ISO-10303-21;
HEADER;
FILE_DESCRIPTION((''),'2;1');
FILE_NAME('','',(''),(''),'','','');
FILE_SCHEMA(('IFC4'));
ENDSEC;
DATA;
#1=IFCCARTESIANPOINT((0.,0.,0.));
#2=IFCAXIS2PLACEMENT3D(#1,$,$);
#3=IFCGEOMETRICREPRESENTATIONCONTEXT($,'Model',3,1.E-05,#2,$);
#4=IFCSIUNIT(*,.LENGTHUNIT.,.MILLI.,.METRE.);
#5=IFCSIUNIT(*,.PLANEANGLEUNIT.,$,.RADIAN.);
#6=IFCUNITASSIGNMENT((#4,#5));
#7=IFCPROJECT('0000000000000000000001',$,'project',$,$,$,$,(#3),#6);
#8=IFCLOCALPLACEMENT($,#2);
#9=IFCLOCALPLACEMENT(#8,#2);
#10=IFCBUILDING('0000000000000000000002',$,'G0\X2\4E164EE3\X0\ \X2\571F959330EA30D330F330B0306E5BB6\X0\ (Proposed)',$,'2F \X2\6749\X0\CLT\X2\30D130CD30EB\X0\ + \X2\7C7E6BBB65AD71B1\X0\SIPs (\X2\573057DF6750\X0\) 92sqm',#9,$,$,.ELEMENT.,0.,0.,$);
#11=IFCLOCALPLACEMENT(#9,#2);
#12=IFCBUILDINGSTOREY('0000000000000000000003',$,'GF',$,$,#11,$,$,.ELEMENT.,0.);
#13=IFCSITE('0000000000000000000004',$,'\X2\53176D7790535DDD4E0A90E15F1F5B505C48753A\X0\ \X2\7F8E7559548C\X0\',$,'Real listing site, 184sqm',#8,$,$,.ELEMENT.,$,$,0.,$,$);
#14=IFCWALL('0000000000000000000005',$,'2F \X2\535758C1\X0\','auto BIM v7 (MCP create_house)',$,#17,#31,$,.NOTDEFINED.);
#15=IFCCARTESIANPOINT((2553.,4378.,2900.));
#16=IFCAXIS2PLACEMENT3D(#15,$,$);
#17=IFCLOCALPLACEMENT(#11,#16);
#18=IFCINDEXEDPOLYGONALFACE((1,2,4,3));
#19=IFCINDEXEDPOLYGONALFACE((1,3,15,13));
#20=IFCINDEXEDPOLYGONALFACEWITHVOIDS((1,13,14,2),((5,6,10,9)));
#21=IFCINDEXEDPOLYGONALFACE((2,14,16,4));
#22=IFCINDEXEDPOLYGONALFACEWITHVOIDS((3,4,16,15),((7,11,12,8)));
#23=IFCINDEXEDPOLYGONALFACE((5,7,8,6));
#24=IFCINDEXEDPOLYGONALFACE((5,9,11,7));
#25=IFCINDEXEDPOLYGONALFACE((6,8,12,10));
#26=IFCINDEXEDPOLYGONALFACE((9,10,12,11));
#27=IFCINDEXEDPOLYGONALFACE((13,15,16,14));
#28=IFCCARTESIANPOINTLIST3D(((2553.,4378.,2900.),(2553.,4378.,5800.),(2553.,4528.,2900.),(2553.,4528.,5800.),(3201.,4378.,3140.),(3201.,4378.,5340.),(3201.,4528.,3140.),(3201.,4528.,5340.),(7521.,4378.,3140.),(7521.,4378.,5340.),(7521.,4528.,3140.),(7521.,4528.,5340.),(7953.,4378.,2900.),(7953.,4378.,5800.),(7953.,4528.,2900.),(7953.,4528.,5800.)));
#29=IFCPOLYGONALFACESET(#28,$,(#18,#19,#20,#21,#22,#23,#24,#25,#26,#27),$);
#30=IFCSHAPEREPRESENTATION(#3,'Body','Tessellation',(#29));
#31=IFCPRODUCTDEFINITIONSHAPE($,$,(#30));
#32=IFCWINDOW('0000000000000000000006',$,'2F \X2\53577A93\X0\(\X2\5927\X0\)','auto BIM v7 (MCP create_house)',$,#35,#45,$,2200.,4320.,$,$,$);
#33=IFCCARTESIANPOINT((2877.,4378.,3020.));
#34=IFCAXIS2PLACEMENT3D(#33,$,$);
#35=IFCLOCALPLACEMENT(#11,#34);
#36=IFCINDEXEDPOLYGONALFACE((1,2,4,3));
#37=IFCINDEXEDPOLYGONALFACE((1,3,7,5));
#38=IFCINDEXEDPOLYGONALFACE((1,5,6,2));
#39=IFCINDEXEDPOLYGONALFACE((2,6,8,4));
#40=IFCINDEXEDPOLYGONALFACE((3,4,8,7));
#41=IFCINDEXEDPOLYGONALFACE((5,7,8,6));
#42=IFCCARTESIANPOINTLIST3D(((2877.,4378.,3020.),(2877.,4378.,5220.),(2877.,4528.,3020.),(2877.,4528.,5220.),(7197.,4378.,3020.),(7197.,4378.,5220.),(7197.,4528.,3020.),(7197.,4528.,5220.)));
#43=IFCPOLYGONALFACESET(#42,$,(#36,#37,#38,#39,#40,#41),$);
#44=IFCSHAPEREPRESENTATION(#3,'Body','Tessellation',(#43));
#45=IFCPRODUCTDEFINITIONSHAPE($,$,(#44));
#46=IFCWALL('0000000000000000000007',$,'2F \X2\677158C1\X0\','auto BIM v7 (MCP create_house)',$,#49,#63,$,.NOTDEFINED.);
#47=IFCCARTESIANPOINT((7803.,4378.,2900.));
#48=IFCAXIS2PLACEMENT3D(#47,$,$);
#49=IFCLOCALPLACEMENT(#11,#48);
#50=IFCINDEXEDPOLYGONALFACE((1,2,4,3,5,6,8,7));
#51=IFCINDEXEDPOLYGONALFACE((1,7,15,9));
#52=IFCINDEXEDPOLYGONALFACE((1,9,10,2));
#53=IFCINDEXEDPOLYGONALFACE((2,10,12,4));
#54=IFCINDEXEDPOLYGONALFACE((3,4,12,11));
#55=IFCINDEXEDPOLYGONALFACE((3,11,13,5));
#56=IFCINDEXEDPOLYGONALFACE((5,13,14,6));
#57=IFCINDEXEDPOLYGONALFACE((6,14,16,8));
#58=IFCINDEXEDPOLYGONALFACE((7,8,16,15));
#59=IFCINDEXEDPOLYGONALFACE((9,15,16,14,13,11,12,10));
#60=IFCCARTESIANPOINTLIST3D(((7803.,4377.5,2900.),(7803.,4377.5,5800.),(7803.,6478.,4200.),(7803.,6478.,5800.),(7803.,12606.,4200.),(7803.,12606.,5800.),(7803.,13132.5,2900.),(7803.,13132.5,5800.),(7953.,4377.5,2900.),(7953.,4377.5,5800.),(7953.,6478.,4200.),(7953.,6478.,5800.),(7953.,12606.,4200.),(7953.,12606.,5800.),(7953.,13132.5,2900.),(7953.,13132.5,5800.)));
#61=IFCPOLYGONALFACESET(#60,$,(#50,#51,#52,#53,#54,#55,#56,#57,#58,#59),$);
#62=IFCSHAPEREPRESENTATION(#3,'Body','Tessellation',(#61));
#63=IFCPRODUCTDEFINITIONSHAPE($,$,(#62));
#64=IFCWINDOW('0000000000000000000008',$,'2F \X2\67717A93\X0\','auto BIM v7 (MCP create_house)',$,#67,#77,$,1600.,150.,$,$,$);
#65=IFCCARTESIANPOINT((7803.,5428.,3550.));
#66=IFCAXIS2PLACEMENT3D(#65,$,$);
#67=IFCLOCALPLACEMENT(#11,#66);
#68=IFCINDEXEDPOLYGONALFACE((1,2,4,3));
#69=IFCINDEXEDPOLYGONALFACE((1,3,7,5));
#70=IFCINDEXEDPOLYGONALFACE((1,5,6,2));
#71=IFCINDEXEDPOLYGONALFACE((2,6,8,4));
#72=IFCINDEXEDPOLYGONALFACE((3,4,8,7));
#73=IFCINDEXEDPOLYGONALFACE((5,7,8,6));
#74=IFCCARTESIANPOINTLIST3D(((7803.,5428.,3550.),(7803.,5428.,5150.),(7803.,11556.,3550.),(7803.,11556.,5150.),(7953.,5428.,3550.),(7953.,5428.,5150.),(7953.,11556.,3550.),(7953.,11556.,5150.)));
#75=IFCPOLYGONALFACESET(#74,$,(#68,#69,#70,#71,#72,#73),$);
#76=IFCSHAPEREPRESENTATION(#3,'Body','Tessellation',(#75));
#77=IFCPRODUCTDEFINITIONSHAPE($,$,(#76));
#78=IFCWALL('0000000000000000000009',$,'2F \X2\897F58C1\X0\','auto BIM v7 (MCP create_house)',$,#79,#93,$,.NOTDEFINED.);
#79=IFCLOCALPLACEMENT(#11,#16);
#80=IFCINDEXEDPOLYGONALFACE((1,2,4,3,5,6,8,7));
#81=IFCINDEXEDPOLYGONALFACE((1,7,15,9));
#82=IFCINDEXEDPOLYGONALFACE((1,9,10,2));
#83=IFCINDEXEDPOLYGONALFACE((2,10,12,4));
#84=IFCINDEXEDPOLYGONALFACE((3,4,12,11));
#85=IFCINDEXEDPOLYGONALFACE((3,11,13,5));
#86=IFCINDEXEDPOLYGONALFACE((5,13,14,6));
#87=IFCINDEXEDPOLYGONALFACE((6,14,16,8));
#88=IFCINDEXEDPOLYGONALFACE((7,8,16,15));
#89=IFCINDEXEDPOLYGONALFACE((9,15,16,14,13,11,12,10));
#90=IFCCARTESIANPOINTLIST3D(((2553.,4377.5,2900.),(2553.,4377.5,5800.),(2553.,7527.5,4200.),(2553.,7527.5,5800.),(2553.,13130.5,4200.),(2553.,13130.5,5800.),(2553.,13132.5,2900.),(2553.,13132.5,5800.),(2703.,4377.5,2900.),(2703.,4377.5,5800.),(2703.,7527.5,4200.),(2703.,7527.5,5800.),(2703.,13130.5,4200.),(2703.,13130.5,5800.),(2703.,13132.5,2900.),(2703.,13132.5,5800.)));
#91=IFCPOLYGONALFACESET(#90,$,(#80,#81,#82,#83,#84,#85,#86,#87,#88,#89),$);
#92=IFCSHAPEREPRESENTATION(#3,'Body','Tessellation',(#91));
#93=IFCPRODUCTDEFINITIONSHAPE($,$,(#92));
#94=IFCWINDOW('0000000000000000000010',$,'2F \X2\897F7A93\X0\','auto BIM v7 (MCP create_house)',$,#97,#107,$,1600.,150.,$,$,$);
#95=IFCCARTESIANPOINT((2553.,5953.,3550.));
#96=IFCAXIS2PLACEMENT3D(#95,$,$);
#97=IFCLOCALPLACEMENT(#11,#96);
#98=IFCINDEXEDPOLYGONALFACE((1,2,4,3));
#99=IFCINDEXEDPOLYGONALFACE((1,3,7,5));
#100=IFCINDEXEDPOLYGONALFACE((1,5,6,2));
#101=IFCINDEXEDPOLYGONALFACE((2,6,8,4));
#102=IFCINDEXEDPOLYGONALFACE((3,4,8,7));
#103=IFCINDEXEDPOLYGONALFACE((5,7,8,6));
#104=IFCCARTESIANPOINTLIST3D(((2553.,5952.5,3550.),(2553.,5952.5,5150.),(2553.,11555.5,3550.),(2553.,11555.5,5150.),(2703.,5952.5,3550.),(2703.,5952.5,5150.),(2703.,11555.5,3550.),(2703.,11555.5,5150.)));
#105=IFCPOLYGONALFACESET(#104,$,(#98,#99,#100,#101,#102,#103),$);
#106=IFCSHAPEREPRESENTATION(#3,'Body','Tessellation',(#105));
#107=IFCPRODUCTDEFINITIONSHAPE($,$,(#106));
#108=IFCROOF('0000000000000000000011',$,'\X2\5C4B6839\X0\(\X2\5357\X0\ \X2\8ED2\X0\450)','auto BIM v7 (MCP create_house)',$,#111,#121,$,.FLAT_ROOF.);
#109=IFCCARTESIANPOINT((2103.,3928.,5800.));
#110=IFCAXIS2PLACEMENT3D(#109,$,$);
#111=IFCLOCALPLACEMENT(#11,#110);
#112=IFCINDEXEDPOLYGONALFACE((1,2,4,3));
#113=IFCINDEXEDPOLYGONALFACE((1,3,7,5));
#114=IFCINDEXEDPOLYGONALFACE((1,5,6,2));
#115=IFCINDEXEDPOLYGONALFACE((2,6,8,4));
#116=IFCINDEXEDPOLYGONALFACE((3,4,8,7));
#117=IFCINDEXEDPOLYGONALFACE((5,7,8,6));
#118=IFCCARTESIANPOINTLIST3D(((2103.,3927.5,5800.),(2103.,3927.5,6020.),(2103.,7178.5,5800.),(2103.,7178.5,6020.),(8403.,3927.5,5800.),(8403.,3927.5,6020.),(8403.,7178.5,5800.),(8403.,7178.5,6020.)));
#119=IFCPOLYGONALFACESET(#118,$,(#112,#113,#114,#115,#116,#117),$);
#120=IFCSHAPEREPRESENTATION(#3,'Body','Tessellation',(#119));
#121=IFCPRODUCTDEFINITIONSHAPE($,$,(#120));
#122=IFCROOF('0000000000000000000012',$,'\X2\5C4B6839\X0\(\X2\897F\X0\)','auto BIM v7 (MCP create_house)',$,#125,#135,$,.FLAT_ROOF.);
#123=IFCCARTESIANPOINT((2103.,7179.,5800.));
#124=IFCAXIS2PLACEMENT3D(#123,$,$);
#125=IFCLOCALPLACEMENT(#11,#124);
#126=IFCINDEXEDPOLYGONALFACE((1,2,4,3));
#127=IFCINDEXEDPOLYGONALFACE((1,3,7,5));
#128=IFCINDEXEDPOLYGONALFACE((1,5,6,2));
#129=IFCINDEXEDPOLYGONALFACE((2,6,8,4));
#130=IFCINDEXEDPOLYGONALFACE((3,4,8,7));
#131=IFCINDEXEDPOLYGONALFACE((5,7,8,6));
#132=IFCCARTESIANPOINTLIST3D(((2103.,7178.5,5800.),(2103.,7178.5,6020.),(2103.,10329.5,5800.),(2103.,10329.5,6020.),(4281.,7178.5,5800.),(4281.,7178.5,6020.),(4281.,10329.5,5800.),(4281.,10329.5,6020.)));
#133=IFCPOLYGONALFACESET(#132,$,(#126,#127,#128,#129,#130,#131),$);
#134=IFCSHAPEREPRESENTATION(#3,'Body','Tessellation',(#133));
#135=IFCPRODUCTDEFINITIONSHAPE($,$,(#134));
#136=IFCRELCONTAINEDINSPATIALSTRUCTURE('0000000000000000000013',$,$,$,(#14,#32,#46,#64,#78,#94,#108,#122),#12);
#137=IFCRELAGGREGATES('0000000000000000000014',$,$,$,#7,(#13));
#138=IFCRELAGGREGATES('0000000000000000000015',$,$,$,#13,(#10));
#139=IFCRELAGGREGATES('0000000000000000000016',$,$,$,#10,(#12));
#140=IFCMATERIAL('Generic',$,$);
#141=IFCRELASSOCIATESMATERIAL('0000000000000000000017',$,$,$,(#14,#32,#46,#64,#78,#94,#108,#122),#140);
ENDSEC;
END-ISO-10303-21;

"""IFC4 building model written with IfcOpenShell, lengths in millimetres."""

from ifc_helpers import new_model, si_unit, frame, frame_2d, origin, place, context, project, spatial, rectangle, extrude, material, element, fill, save


model = new_model("IFC4")

# Units and contexts
model_context = context("Model", 3, precision=1e-05, world=origin())
ifc_project = project(units=[si_unit("LENGTHUNIT", "METRE", prefix="MILLI"), si_unit("PLANEANGLEUNIT", "RADIAN")], contexts=[model_context])

# Site, building, storey
site_placement = place(None, origin())
site = spatial("IfcSite", under=ifc_project, at=site_placement, Name="北海道川上郡弟子屈町 美留和", ObjectType="Real listing site, 184sqm", CompositionType="ELEMENT", RefElevation=0.0)
building_placement = place(site_placement, origin())
building = spatial("IfcBuilding", under=site, at=building_placement, Name="G0世代 土間リビングの家 (Proposed)", ObjectType="2F 杉CLTパネル + 籾殻断熱SIPs (地域材) 92sqm", CompositionType="ELEMENT", ElevationOfRefHeight=0.0, ElevationOfTerrain=0.0)
storey_placement = place(building_placement, origin())
storey = spatial("IfcBuildingStorey", under=building, at=storey_placement, Name="GF", CompositionType="ELEMENT", Elevation=0.0)

# Shared definitions
ifc_material = material(Name="Generic")

# Walls, openings, windows
wall_1_placement = place(storey_placement, frame((2553.0, 4378.0, 2900.0)))
wall_1 = element("IfcWall", 1, at=wall_1_placement, inside=storey, material=ifc_material, Name="2F 南壁", Description="auto BIM v7 (MCP create_house)", PredefinedType="NOTDEFINED", context=model_context, shape_type="SweptSolid", body=[
    extrude(rectangle(XDim=5400.0, YDim=150.0, at=frame_2d((2700.0, 75.0))), frame((2553.0, 4378.0, 2900.0)), (0.0, 0.0, 1.0), 2900.0),
])
opening_1_placement = place(storey_placement, frame((2877.0, 4378.0, 3020.0)))
opening_1 = element("IfcOpeningElement", 2, at=opening_1_placement, cuts=wall_1, PredefinedType="NOTDEFINED", context=model_context, shape_type="SweptSolid", body=[
    extrude(rectangle(XDim=4320.0, YDim=150.0, at=frame_2d((2160.0, 75.0))), frame((2877.0, 4378.0, 3020.0)), (0.0, 0.0, 1.0), 2200.0),
])
window_1_placement = place(storey_placement, frame((2877.0, 4378.0, 3020.0)))
window_1 = element("IfcWindow", 3, at=window_1_placement, inside=storey, material=ifc_material, Name="2F 南窓(大)", Description="auto BIM v7 (MCP create_house)", OverallHeight=2200.0, OverallWidth=4320.0, context=model_context, shape_type="SweptSolid", body=[
    extrude(rectangle(XDim=4320.0, YDim=150.0, at=frame_2d((2160.0, 75.0))), frame((2877.0, 4378.0, 3020.0)), (0.0, 0.0, 1.0), 2200.0),
])
fill(opening_1, window_1)
wall_2_placement = place(storey_placement, frame((7803.0, 4378.0, 2900.0)))
wall_2 = element("IfcWall", 4, at=wall_2_placement, inside=storey, material=ifc_material, Name="2F 東壁", Description="auto BIM v7 (MCP create_house)", PredefinedType="NOTDEFINED", context=model_context, shape_type="SweptSolid", body=[
    extrude(rectangle(XDim=150.0, YDim=8755.0, at=frame_2d((75.0, 4377.0))), frame((7803.0, 4378.0, 2900.0)), (0.0, 0.0, 1.0), 2900.0),
])
opening_2_placement = place(storey_placement, frame((7803.0, 5428.0, 3550.0)))
opening_2 = element("IfcOpeningElement", 5, at=opening_2_placement, cuts=wall_2, PredefinedType="NOTDEFINED", context=model_context, shape_type="SweptSolid", body=[
    extrude(rectangle(XDim=150.0, YDim=6128.0, at=frame_2d((75.0, 3064.0))), frame((7803.0, 5428.0, 3550.0)), (0.0, 0.0, 1.0), 1600.0),
])
window_2_placement = place(storey_placement, frame((7803.0, 5428.0, 3550.0)))
window_2 = element("IfcWindow", 6, at=window_2_placement, inside=storey, material=ifc_material, Name="2F 東窓", Description="auto BIM v7 (MCP create_house)", OverallHeight=1600.0, OverallWidth=150.0, context=model_context, shape_type="SweptSolid", body=[
    extrude(rectangle(XDim=150.0, YDim=6128.0, at=frame_2d((75.0, 3064.0))), frame((7803.0, 5428.0, 3550.0)), (0.0, 0.0, 1.0), 1600.0),
])
fill(opening_2, window_2)
wall_3_placement = place(storey_placement, frame((2553.0, 4378.0, 2900.0)))
wall_3 = element("IfcWall", 7, at=wall_3_placement, inside=storey, material=ifc_material, Name="2F 西壁", Description="auto BIM v7 (MCP create_house)", PredefinedType="NOTDEFINED", context=model_context, shape_type="SweptSolid", body=[
    extrude(rectangle(XDim=150.0, YDim=8755.0, at=frame_2d((75.0, 4377.0))), frame((2553.0, 4378.0, 2900.0)), (0.0, 0.0, 1.0), 2900.0),
])
opening_3_placement = place(storey_placement, frame((2553.0, 5953.0, 3550.0)))
opening_3 = element("IfcOpeningElement", 8, at=opening_3_placement, cuts=wall_3, PredefinedType="NOTDEFINED", context=model_context, shape_type="SweptSolid", body=[
    extrude(rectangle(XDim=150.0, YDim=5603.0, at=frame_2d((75.0, 2801.0))), frame((2553.0, 5953.0, 3550.0)), (0.0, 0.0, 1.0), 1600.0),
])
window_3_placement = place(storey_placement, frame((2553.0, 5953.0, 3550.0)))
window_3 = element("IfcWindow", 9, at=window_3_placement, inside=storey, material=ifc_material, Name="2F 西窓", Description="auto BIM v7 (MCP create_house)", OverallHeight=1600.0, OverallWidth=150.0, context=model_context, shape_type="SweptSolid", body=[
    extrude(rectangle(XDim=150.0, YDim=5603.0, at=frame_2d((75.0, 2801.0))), frame((2553.0, 5953.0, 3550.0)), (0.0, 0.0, 1.0), 1600.0),
])
fill(opening_3, window_3)

# Roofs
roof_1_placement = place(storey_placement, frame((2103.0, 3928.0, 5800.0)))
element("IfcRoof", 10, at=roof_1_placement, inside=storey, material=ifc_material, Name="屋根(南 軒450)", Description="auto BIM v7 (MCP create_house)", PredefinedType="FLAT_ROOF", context=model_context, shape_type="SweptSolid", body=[
    extrude(rectangle(XDim=6300.0, YDim=3251.0, at=frame_2d((3150.0, 1625.0))), frame((2103.0, 3928.0, 5800.0)), (0.0, 0.0, 1.0), 220.0),
])
roof_2_placement = place(storey_placement, frame((2103.0, 7179.0, 5800.0)))
element("IfcRoof", 11, at=roof_2_placement, inside=storey, material=ifc_material, Name="屋根(西)", Description="auto BIM v7 (MCP create_house)", PredefinedType="FLAT_ROOF", context=model_context, shape_type="SweptSolid", body=[
    extrude(rectangle(XDim=2178.0, YDim=3151.0, at=frame_2d((1089.0, 1575.0))), frame((2103.0, 7179.0, 5800.0)), (0.0, 0.0, 1.0), 220.0),
])

save(model, "model.ifc")
